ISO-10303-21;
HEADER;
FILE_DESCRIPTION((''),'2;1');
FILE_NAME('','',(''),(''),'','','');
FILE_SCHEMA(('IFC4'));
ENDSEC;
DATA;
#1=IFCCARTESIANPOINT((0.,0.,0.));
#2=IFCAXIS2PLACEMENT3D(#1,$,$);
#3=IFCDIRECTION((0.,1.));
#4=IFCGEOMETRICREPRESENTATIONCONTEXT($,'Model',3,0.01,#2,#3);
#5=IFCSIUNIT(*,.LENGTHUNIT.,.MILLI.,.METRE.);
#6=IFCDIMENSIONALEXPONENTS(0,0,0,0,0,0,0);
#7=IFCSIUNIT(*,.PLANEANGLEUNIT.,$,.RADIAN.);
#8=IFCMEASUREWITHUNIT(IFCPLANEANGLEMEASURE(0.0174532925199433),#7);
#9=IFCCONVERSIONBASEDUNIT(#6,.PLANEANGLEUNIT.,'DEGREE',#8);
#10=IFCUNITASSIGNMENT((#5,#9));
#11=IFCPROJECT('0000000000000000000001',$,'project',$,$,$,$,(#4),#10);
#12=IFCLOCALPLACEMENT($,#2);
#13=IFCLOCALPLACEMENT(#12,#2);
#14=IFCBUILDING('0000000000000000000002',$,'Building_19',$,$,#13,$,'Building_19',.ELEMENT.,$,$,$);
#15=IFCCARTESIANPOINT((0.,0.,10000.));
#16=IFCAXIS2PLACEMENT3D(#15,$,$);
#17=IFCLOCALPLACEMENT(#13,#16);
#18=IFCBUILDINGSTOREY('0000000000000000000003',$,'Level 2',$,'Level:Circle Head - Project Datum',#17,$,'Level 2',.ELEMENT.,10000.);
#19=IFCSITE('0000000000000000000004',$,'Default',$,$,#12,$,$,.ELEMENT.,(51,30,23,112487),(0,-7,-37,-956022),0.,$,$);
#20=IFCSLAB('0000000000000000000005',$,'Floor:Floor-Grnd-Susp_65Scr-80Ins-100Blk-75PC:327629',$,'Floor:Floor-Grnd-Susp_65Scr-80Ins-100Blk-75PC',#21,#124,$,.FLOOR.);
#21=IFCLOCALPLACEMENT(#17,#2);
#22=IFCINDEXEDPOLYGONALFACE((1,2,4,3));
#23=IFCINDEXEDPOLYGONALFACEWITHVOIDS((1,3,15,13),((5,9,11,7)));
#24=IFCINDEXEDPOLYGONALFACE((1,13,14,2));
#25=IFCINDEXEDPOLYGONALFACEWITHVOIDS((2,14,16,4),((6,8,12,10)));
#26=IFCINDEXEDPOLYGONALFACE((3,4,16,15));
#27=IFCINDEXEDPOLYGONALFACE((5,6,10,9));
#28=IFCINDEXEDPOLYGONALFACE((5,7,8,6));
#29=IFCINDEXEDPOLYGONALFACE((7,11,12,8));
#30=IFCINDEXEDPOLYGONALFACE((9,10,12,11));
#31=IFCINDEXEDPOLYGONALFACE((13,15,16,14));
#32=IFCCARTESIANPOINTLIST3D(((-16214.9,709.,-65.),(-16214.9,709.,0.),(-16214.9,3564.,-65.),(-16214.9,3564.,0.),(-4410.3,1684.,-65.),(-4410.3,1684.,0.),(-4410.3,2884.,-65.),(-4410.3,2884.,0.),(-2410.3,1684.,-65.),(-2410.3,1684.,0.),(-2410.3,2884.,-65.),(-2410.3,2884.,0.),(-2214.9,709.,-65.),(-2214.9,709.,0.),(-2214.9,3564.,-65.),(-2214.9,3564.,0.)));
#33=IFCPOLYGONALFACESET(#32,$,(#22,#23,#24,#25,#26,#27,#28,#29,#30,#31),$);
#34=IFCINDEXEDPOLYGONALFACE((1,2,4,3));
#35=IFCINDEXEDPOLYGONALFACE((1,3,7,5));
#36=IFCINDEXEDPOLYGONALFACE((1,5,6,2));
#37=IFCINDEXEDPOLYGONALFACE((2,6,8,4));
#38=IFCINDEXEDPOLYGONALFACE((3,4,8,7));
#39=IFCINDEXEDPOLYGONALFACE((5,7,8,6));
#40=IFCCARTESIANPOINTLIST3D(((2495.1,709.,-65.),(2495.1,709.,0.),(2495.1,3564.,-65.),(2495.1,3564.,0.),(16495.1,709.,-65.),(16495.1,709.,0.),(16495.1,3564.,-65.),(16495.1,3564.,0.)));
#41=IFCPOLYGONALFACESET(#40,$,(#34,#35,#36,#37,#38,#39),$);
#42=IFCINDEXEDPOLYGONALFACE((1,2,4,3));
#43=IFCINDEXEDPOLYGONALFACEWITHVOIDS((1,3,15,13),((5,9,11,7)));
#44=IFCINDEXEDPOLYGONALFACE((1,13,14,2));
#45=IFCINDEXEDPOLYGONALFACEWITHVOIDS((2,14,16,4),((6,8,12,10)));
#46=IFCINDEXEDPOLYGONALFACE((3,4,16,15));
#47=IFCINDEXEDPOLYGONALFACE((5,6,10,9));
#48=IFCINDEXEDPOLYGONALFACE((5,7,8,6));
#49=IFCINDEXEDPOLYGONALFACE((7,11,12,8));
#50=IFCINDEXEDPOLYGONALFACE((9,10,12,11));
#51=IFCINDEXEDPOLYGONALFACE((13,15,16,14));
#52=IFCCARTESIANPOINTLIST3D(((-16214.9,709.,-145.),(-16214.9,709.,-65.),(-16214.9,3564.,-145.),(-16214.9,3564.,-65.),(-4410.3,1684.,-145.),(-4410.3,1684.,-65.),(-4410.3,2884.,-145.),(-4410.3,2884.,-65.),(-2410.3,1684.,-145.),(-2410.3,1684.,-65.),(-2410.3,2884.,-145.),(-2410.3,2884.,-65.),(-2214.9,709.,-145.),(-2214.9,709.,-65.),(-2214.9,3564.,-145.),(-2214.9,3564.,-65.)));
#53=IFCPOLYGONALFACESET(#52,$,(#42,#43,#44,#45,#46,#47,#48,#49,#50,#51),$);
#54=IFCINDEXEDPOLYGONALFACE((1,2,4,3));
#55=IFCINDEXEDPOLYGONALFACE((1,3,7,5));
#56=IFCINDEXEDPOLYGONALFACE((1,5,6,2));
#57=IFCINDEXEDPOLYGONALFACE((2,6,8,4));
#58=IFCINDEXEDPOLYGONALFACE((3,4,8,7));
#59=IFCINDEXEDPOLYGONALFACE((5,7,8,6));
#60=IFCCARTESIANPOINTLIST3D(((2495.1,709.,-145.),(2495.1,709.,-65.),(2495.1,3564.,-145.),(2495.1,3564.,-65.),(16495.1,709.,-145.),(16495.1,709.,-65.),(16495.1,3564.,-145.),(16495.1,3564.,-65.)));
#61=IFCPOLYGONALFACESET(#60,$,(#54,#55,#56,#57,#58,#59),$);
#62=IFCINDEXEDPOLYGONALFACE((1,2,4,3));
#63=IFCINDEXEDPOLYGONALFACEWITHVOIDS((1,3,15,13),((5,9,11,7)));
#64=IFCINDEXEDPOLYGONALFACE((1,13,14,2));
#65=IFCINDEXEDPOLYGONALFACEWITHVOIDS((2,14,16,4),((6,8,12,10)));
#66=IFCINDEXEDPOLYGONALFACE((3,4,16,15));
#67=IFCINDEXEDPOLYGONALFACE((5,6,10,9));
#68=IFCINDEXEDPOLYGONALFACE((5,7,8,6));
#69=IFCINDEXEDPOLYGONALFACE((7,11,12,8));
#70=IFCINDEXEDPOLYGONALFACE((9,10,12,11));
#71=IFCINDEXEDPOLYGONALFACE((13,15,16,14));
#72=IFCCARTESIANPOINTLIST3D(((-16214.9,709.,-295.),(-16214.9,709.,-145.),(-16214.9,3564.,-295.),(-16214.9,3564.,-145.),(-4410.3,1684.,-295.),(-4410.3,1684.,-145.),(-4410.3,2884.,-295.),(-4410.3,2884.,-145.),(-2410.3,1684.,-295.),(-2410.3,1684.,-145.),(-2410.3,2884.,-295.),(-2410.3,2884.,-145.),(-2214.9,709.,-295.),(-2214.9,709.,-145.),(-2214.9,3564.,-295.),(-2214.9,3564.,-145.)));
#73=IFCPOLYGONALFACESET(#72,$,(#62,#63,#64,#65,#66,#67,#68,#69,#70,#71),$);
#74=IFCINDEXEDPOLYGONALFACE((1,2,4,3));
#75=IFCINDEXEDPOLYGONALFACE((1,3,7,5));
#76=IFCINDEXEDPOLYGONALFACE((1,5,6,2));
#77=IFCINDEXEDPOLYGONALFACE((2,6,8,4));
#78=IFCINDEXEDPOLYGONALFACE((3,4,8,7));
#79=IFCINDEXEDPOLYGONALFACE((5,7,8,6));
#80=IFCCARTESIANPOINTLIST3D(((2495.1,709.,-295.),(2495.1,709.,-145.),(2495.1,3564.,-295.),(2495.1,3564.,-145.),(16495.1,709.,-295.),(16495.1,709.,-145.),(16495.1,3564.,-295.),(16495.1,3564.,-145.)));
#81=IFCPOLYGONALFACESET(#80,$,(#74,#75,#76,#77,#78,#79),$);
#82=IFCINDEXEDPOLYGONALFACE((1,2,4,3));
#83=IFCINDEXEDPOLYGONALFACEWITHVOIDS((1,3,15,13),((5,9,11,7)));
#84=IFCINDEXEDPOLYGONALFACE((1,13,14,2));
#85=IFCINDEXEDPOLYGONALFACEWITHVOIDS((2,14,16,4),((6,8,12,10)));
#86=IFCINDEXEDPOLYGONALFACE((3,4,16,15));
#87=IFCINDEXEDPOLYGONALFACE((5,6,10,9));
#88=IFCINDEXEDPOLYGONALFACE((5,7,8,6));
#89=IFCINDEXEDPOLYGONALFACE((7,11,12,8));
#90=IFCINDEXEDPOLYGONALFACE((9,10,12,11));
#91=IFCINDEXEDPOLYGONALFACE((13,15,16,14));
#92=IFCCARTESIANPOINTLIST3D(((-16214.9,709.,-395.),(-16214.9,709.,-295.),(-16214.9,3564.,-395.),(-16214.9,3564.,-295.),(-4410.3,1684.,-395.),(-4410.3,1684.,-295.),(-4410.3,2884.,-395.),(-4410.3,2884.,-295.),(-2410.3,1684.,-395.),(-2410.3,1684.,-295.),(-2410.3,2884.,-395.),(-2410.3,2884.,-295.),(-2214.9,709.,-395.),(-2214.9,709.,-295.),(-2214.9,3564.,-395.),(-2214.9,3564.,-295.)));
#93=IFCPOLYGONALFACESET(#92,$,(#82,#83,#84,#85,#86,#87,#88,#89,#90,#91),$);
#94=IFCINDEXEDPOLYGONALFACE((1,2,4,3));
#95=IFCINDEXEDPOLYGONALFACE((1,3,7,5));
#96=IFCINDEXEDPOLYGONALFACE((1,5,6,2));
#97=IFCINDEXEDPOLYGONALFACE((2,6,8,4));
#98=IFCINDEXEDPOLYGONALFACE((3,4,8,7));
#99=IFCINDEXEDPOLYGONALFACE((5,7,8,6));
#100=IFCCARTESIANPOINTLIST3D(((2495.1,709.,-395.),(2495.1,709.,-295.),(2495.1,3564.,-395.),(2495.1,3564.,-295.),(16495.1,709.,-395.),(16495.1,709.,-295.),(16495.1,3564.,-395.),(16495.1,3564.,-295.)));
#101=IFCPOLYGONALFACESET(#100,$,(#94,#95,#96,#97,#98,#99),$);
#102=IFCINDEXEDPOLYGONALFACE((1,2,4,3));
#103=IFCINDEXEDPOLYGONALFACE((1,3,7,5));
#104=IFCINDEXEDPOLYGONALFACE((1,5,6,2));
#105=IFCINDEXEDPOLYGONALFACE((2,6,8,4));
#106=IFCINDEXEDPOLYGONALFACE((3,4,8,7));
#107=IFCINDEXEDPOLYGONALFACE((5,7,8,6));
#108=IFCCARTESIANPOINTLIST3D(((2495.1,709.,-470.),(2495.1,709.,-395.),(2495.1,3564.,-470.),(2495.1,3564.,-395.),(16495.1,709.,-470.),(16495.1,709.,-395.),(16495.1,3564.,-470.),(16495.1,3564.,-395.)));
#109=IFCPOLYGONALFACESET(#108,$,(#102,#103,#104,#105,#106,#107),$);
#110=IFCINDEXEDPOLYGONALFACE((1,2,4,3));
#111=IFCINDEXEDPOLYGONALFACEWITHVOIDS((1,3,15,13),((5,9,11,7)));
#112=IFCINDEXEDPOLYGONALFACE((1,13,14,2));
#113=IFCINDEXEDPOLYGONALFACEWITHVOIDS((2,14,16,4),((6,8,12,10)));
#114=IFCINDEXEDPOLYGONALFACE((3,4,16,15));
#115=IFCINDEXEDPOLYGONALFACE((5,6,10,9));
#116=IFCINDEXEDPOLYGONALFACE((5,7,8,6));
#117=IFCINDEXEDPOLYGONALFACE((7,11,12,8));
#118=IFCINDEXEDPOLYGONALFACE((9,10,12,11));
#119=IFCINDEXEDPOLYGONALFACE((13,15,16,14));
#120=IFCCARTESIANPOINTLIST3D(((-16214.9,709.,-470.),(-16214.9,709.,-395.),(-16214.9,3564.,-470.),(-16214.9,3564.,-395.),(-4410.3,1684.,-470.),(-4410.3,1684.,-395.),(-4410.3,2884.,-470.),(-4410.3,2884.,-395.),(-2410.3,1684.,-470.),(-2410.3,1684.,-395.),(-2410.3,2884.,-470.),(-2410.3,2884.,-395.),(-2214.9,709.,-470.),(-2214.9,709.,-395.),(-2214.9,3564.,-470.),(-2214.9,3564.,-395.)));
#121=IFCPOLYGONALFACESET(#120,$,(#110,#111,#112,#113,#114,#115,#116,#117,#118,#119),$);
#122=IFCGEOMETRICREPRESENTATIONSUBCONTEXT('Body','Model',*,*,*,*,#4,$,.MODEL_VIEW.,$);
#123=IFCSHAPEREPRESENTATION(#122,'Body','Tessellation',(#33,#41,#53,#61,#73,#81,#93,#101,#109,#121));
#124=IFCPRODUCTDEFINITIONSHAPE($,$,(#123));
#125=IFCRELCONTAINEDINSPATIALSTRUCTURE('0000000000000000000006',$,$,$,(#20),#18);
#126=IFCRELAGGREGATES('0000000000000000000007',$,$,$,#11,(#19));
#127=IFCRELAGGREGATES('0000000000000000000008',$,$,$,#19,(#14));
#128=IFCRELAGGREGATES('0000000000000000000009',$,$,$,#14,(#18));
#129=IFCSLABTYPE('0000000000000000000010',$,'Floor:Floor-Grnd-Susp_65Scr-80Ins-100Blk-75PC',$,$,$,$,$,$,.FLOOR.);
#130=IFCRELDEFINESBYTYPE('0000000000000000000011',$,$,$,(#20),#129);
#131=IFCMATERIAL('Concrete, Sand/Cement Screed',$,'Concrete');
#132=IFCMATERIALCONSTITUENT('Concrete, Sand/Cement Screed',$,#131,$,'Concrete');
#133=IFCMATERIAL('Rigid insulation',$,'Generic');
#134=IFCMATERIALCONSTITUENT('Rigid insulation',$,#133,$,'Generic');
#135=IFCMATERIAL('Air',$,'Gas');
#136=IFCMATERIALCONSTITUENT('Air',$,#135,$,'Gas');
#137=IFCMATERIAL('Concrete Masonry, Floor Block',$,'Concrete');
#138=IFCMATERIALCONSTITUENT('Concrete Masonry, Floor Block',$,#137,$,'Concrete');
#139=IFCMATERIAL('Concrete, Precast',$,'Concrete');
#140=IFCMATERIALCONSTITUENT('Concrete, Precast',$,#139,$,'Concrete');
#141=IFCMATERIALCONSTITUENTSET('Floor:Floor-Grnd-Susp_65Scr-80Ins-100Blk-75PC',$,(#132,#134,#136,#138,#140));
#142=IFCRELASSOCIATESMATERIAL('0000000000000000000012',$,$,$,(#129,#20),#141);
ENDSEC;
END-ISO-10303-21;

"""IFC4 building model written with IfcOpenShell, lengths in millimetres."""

from ifc_helpers import new_model, entity, si_unit, converted_unit, direction, frame, origin, place, context, subcontext, project, spatial, indexed_curve, outline, extrude, material, constituent, constituent_set, type_object, element, save


model = new_model("IFC4")

# Units and contexts
model_context = context("Model", 3, precision=0.01, world=origin(), true_north=direction((0.0, 1.0)))
body_context = subcontext(model_context, "Body", "Model", "MODEL_VIEW")
ifc_project = project(units=[si_unit("LENGTHUNIT", "METRE", prefix="MILLI"), converted_unit("PLANEANGLEUNIT", "DEGREE", entity("IfcPlaneAngleMeasure", 0.0174532925199433), si_unit("PLANEANGLEUNIT", "RADIAN"), dimensions=[0, 0, 0, 0, 0, 0, 0])], contexts=[model_context])

# Site, building, storey
site_placement = place(None, origin())
site = spatial("IfcSite", under=ifc_project, at=site_placement, Name="Default", CompositionType="ELEMENT", RefLatitude=(51, 30, 23, 112487), RefLongitude=(0, -7, -37, -956022), RefElevation=0.0)
building_placement = place(site_placement, origin())
building = spatial("IfcBuilding", under=site, at=building_placement, Name="Building_19", LongName="Building_19", CompositionType="ELEMENT")
storey_placement = place(building_placement, frame((0.0, 0.0, 10000.0)))
storey = spatial("IfcBuildingStorey", under=building, at=storey_placement, Name="Level 2", ObjectType="Level:Circle Head - Project Datum", LongName="Level 2", CompositionType="ELEMENT", Elevation=10000.0)

# Slab, opening
ifc_material_1 = material(Name="Concrete, Sand/Cement Screed", Category="Concrete")
ifc_constituent_1 = constituent(ifc_material_1, Name="Concrete, Sand/Cement Screed", Category="Concrete")
ifc_material_2 = material(Name="Rigid insulation", Category="Generic")
ifc_constituent_2 = constituent(ifc_material_2, Name="Rigid insulation", Category="Generic")
ifc_material_3 = material(Name="Air", Category="Gas")
ifc_constituent_3 = constituent(ifc_material_3, Name="Air", Category="Gas")
ifc_material_4 = material(Name="Concrete Masonry, Floor Block", Category="Concrete")
ifc_constituent_4 = constituent(ifc_material_4, Name="Concrete Masonry, Floor Block", Category="Concrete")
ifc_material_5 = material(Name="Concrete, Precast", Category="Concrete")
ifc_constituent_5 = constituent(ifc_material_5, Name="Concrete, Precast", Category="Concrete")
ifc_constituent_set_1 = constituent_set(constituents=[ifc_constituent_1, ifc_constituent_2, ifc_constituent_3, ifc_constituent_4, ifc_constituent_5], Name="Floor:Floor-Grnd-Susp_65Scr-80Ins-100Blk-75PC")
slab_type = type_object("IfcSlabType", Name="Floor:Floor-Grnd-Susp_65Scr-80Ins-100Blk-75PC", PredefinedType="FLOOR", material=ifc_constituent_set_1)
slab_1_placement = place(storey_placement, origin())
slab_1 = element("IfcSlab", 1, at=slab_1_placement, inside=storey, type_object=slab_type, material=ifc_constituent_set_1, Name="Floor:Floor-Grnd-Susp_65Scr-80Ins-100Blk-75PC:327629", ObjectType="Floor:Floor-Grnd-Susp_65Scr-80Ins-100Blk-75PC", PredefinedType="FLOOR", context=body_context, shape_type="SweptSolid", body=[
    extrude(outline(indexed_curve([(-7000.0, -1427.5), (7000.0, -1427.5), (7000.0, 1427.5), (-7000.0, 1427.5), (-7000.0, -1427.5)], self_intersect=False), holes=[indexed_curve([(-4804.6, -747.5), (-6804.6, -747.5), (-6804.6, 452.5), (-4804.6, 452.5), (-4804.6, -747.5)], self_intersect=False)]), frame((-9214.9, 2136.5, -65.0), z_axis=(0.0, 0.0, 1.0), x_axis=(-1.0, 0.0, 0.0)), (0.0, 0.0, 1.0), 65.0),
    extrude(outline(indexed_curve([(-7000.0, -1427.5), (7000.0, -1427.5), (7000.0, 1427.5), (-7000.0, 1427.5), (-7000.0, -1427.5)], self_intersect=False)), frame((9495.1, 2136.5, -65.0), z_axis=(0.0, 0.0, 1.0), x_axis=(-1.0, 0.0, 0.0)), (0.0, 0.0, 1.0), 65.0),
    extrude(outline(indexed_curve([(-7000.0, -1427.5), (7000.0, -1427.5), (7000.0, 1427.5), (-7000.0, 1427.5), (-7000.0, -1427.5)], self_intersect=False), holes=[indexed_curve([(-4804.6, -747.5), (-6804.6, -747.5), (-6804.6, 452.5), (-4804.6, 452.5), (-4804.6, -747.5)], self_intersect=False)]), frame((-9214.9, 2136.5, -145.0), z_axis=(0.0, 0.0, 1.0), x_axis=(-1.0, 0.0, 0.0)), (0.0, 0.0, 1.0), 80.0),
    extrude(outline(indexed_curve([(-7000.0, -1427.5), (7000.0, -1427.5), (7000.0, 1427.5), (-7000.0, 1427.5), (-7000.0, -1427.5)], self_intersect=False)), frame((9495.1, 2136.5, -145.0), z_axis=(0.0, 0.0, 1.0), x_axis=(-1.0, 0.0, 0.0)), (0.0, 0.0, 1.0), 80.0),
    extrude(outline(indexed_curve([(-7000.0, -1427.5), (7000.0, -1427.5), (7000.0, 1427.5), (-7000.0, 1427.5), (-7000.0, -1427.5)], self_intersect=False), holes=[indexed_curve([(-4804.6, -747.5), (-6804.6, -747.5), (-6804.6, 452.5), (-4804.6, 452.5), (-4804.6, -747.5)], self_intersect=False)]), frame((-9214.9, 2136.5, -295.0), z_axis=(0.0, 0.0, 1.0), x_axis=(-1.0, 0.0, 0.0)), (0.0, 0.0, 1.0), 150.0),
    extrude(outline(indexed_curve([(-7000.0, -1427.5), (7000.0, -1427.5), (7000.0, 1427.5), (-7000.0, 1427.5), (-7000.0, -1427.5)], self_intersect=False)), frame((9495.1, 2136.5, -295.0), z_axis=(0.0, 0.0, 1.0), x_axis=(-1.0, 0.0, 0.0)), (0.0, 0.0, 1.0), 150.0),
    extrude(outline(indexed_curve([(-7000.0, -1427.5), (7000.0, -1427.5), (7000.0, 1427.5), (-7000.0, 1427.5), (-7000.0, -1427.5)], self_intersect=False), holes=[indexed_curve([(-4804.6, -747.5), (-6804.6, -747.5), (-6804.6, 452.5), (-4804.6, 452.5), (-4804.6, -747.5)], self_intersect=False)]), frame((-9214.9, 2136.5, -395.0), z_axis=(0.0, 0.0, 1.0), x_axis=(-1.0, 0.0, 0.0)), (0.0, 0.0, 1.0), 100.0),
    extrude(outline(indexed_curve([(-7000.0, -1427.5), (7000.0, -1427.5), (7000.0, 1427.5), (-7000.0, 1427.5), (-7000.0, -1427.5)], self_intersect=False)), frame((9495.1, 2136.5, -395.0), z_axis=(0.0, 0.0, 1.0), x_axis=(-1.0, 0.0, 0.0)), (0.0, 0.0, 1.0), 100.0),
    extrude(outline(indexed_curve([(-7000.0, -1427.5), (7000.0, -1427.5), (7000.0, 1427.5), (-7000.0, 1427.5), (-7000.0, -1427.5)], self_intersect=False)), frame((9495.1, 2136.5, -470.0), z_axis=(0.0, 0.0, 1.0), x_axis=(-1.0, 0.0, 0.0)), (0.0, 0.0, 1.0), 75.0),
    extrude(outline(indexed_curve([(-7000.0, -1427.5), (7000.0, -1427.5), (7000.0, 1427.5), (-7000.0, 1427.5), (-7000.0, -1427.5)], self_intersect=False), holes=[indexed_curve([(-4804.6, -747.5), (-6804.6, -747.5), (-6804.6, 452.5), (-4804.6, 452.5), (-4804.6, -747.5)], self_intersect=False)]), frame((-9214.9, 2136.5, -470.0), z_axis=(0.0, 0.0, 1.0), x_axis=(-1.0, 0.0, 0.0)), (0.0, 0.0, 1.0), 75.0),
])
opening_1_placement = place(slab_1_placement, origin())
element("IfcOpeningElement", 2, at=opening_1_placement, cuts=slab_1, PredefinedType="OPENING", context=body_context, shape_type="SweptSolid", body=[
    extrude(outline(indexed_curve([(-600.0, -1000.0), (600.0, -1000.0), (600.0, 1000.0), (-600.0, 1000.0), (-600.0, -1000.0)], self_intersect=False)), frame((-3410.3, 2284.0, -470.0), z_axis=(0.0, 0.0, 1.0), x_axis=(0.0, -1.0, 0.0)), (0.0, 0.0, 1.0), 470.0),
])

save(model, "model.ifc")
